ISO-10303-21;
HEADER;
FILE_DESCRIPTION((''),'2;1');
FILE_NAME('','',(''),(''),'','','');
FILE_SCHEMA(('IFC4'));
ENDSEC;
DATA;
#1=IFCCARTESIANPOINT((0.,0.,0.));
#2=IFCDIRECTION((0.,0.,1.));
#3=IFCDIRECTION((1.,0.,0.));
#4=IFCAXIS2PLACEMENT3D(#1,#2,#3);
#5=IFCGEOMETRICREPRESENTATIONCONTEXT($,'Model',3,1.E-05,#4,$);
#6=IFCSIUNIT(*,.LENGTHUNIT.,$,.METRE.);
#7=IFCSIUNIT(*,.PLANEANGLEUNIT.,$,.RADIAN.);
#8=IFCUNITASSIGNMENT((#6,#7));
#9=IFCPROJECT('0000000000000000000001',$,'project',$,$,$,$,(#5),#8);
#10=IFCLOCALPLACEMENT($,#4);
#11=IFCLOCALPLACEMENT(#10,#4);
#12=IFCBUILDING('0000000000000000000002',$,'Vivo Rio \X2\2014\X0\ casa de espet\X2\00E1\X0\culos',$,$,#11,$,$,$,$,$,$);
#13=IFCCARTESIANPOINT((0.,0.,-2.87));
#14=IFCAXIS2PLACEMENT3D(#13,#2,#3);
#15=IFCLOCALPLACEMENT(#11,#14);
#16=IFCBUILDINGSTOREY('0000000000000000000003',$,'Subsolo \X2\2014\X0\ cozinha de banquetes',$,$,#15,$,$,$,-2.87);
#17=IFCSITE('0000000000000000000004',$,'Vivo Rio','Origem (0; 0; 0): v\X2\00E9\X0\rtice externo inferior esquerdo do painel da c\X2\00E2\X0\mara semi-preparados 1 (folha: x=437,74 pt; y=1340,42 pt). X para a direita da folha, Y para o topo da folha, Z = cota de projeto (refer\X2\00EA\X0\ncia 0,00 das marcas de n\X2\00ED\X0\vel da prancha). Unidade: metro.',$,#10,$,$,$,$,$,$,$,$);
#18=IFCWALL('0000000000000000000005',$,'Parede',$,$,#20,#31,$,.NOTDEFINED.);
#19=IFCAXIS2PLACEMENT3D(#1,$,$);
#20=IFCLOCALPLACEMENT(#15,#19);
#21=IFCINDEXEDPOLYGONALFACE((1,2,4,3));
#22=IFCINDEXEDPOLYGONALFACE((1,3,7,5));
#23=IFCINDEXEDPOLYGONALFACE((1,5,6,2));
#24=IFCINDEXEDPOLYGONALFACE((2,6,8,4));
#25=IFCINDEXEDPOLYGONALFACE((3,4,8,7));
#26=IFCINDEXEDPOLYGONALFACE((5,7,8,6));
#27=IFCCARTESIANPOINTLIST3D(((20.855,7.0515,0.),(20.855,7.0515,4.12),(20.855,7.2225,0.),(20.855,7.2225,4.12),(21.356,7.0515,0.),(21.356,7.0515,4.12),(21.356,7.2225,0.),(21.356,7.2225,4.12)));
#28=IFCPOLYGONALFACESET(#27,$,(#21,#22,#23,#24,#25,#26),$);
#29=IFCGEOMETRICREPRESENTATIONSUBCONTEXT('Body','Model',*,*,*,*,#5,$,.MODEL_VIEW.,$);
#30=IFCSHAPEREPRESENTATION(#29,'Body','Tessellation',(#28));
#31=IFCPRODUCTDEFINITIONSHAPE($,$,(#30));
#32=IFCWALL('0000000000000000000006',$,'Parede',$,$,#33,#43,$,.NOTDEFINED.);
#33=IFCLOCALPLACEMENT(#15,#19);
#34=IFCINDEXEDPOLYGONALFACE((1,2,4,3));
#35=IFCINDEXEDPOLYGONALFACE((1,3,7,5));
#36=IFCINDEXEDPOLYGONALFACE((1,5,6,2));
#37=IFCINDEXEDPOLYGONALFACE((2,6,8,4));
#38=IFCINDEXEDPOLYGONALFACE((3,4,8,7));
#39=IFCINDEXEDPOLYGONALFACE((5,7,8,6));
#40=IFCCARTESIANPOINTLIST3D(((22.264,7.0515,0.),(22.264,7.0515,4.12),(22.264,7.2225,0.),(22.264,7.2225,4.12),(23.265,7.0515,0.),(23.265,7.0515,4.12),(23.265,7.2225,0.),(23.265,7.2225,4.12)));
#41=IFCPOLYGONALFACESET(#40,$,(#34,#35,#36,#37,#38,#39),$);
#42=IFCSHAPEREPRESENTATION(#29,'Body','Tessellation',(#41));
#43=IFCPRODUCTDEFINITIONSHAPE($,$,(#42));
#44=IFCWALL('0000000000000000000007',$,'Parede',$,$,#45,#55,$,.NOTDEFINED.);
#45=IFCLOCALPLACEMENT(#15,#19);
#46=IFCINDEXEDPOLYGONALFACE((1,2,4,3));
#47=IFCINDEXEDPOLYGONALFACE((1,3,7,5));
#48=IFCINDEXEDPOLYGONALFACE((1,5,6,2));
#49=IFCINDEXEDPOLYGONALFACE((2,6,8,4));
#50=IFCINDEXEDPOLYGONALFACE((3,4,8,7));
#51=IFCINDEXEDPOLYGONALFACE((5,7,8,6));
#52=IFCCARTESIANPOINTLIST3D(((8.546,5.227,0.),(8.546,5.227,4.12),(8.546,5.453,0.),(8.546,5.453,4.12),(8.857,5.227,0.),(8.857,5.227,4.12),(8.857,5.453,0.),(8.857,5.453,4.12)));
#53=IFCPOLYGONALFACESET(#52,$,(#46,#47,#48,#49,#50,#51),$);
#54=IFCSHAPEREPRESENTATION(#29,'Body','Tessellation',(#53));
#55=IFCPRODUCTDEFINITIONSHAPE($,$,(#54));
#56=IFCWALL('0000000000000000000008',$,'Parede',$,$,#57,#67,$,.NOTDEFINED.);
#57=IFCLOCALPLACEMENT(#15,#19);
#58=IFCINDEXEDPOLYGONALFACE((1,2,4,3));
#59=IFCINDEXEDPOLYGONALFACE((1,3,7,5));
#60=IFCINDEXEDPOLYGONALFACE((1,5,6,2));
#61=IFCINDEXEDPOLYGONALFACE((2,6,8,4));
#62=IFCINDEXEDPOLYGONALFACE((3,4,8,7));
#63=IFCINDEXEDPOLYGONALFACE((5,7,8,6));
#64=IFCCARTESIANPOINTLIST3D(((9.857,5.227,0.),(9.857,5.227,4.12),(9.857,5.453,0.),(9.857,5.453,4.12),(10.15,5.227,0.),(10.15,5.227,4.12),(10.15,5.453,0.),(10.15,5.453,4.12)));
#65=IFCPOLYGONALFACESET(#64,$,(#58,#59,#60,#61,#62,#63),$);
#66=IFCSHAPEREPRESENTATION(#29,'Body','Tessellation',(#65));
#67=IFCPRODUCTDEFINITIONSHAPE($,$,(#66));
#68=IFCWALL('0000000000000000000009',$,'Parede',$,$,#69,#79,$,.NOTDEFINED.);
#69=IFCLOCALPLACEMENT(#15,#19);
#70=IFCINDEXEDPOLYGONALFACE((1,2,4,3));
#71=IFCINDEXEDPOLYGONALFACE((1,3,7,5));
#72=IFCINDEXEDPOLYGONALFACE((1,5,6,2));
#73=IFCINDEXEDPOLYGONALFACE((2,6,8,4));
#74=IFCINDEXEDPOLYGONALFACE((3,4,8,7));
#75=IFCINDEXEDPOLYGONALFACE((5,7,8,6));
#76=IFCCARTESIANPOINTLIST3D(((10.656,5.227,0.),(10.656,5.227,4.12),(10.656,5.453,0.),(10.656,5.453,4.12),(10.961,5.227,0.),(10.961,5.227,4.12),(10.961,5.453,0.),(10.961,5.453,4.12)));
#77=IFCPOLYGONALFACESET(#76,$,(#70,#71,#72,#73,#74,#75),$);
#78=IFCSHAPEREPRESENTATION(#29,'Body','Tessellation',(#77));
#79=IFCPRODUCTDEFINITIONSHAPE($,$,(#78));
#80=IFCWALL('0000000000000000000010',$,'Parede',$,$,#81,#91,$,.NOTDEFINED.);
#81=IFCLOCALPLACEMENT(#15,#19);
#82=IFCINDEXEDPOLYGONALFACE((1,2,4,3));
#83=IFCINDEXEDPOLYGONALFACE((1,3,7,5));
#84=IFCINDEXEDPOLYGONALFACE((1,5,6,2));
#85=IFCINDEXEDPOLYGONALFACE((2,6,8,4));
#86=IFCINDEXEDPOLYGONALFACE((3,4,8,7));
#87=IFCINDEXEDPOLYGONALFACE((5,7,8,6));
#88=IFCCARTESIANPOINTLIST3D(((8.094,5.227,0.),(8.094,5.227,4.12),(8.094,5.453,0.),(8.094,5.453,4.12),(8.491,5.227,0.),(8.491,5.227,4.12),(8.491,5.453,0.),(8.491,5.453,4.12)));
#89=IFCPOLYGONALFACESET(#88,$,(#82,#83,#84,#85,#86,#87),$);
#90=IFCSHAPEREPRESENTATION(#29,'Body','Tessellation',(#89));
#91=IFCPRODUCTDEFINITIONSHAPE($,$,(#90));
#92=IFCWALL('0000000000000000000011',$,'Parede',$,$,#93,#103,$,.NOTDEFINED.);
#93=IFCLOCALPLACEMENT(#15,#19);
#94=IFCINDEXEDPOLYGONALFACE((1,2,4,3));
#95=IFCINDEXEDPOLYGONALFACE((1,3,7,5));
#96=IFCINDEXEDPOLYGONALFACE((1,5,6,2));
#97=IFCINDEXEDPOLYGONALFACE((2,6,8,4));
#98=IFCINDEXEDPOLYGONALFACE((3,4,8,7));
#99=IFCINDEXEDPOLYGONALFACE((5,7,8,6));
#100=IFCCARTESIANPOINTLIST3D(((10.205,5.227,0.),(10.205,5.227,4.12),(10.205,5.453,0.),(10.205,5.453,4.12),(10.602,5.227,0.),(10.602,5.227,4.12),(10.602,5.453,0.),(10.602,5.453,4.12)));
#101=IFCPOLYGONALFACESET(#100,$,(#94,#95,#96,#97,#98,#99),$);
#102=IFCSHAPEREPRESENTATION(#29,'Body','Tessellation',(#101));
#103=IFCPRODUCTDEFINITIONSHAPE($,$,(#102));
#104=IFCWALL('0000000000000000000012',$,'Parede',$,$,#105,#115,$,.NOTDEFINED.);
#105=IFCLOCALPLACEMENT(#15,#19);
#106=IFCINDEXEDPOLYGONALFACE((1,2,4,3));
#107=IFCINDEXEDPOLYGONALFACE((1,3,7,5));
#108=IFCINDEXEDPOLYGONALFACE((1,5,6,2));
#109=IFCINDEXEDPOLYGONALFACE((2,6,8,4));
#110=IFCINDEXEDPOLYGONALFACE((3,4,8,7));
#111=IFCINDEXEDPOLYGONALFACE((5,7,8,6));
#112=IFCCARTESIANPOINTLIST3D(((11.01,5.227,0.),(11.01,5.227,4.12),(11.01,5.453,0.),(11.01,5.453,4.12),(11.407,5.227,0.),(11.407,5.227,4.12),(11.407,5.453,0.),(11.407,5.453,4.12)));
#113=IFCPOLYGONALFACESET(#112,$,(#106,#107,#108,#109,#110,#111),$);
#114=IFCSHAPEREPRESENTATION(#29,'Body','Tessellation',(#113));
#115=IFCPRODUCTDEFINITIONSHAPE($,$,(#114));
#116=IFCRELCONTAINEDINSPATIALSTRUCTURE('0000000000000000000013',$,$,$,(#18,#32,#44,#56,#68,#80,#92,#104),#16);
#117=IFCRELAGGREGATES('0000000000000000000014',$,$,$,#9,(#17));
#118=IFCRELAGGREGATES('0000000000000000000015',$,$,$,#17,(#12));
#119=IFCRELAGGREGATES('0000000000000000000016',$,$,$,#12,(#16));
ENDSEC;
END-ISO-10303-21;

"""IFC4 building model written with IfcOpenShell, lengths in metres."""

from ifc_helpers import new_model, si_unit, frame, origin_with_axes, origin_2d, place, context, subcontext, project, spatial, rectangle, extrude, element, save


model = new_model("IFC4")

# Units and contexts
model_context = context("Model", 3, precision=1e-05, world=origin_with_axes())
body_context = subcontext(model_context, "Body", "Model", "MODEL_VIEW")
ifc_project = project(units=[si_unit("LENGTHUNIT", "METRE"), si_unit("PLANEANGLEUNIT", "RADIAN")], contexts=[model_context])

# Site, building, storey
site_placement = place(None, origin_with_axes())
site = spatial("IfcSite", under=ifc_project, at=site_placement, Name="Vivo Rio", Description="Origem (0; 0; 0): vértice externo inferior esquerdo do painel da câmara semi-preparados 1 (folha: x=437,74 pt; y=1340,42 pt). X para a direita da folha, Y para o topo da folha, Z = cota de projeto (referência 0,00 das marcas de nível da prancha). Unidade: metro.")
building_placement = place(site_placement, origin_with_axes())
building = spatial("IfcBuilding", under=site, at=building_placement, Name="Vivo Rio — casa de espetáculos")
storey_placement = place(building_placement, frame((0.0, 0.0, -2.87), z_axis=(0.0, 0.0, 1.0), x_axis=(1.0, 0.0, 0.0)))
storey = spatial("IfcBuildingStorey", under=building, at=storey_placement, Name="Subsolo — cozinha de banquetes", Elevation=-2.87)

# Walls
wall_1_placement = place(storey_placement, origin_with_axes())
element("IfcWall", 1, at=wall_1_placement, inside=storey, Name="Parede", PredefinedType="NOTDEFINED", context=body_context, shape_type="SweptSolid", body=[
    extrude(rectangle(XDim=0.501, YDim=0.171, at=origin_2d()), frame((21.1055, 7.137, 0.0), z_axis=(0.0, 0.0, 1.0), x_axis=(1.0, 0.0, 0.0)), (0.0, 0.0, 1.0), 4.12),
])
wall_2_placement = place(storey_placement, origin_with_axes())
element("IfcWall", 2, at=wall_2_placement, inside=storey, Name="Parede", PredefinedType="NOTDEFINED", context=body_context, shape_type="SweptSolid", body=[
    extrude(rectangle(XDim=1.001, YDim=0.171, at=origin_2d()), frame((22.7645, 7.137, 0.0), z_axis=(0.0, 0.0, 1.0), x_axis=(1.0, 0.0, 0.0)), (0.0, 0.0, 1.0), 4.12),
])
wall_3_placement = place(storey_placement, origin_with_axes())
element("IfcWall", 3, at=wall_3_placement, inside=storey, Name="Parede", PredefinedType="NOTDEFINED", context=body_context, shape_type="SweptSolid", body=[
    extrude(rectangle(XDim=0.311, YDim=0.226, at=origin_2d()), frame((8.7015, 5.34, 0.0), z_axis=(0.0, 0.0, 1.0), x_axis=(1.0, 0.0, 0.0)), (0.0, 0.0, 1.0), 4.12),
])
wall_4_placement = place(storey_placement, origin_with_axes())
element("IfcWall", 4, at=wall_4_placement, inside=storey, Name="Parede", PredefinedType="NOTDEFINED", context=body_context, shape_type="SweptSolid", body=[
    extrude(rectangle(XDim=0.293, YDim=0.226, at=origin_2d()), frame((10.0035, 5.34, 0.0), z_axis=(0.0, 0.0, 1.0), x_axis=(1.0, 0.0, 0.0)), (0.0, 0.0, 1.0), 4.12),
])
wall_5_placement = place(storey_placement, origin_with_axes())
element("IfcWall", 5, at=wall_5_placement, inside=storey, Name="Parede", PredefinedType="NOTDEFINED", context=body_context, shape_type="SweptSolid", body=[
    extrude(rectangle(XDim=0.305, YDim=0.226, at=origin_2d()), frame((10.8085, 5.34, 0.0), z_axis=(0.0, 0.0, 1.0), x_axis=(1.0, 0.0, 0.0)), (0.0, 0.0, 1.0), 4.12),
])
wall_6_placement = place(storey_placement, origin_with_axes())
element("IfcWall", 6, at=wall_6_placement, inside=storey, Name="Parede", PredefinedType="NOTDEFINED", context=body_context, shape_type="SweptSolid", body=[
    extrude(rectangle(XDim=0.397, YDim=0.226, at=origin_2d()), frame((8.2925, 5.34, 0.0), z_axis=(0.0, 0.0, 1.0), x_axis=(1.0, 0.0, 0.0)), (0.0, 0.0, 1.0), 4.12),
])
wall_7_placement = place(storey_placement, origin_with_axes())
element("IfcWall", 7, at=wall_7_placement, inside=storey, Name="Parede", PredefinedType="NOTDEFINED", context=body_context, shape_type="SweptSolid", body=[
    extrude(rectangle(XDim=0.397, YDim=0.226, at=origin_2d()), frame((10.4035, 5.34, 0.0), z_axis=(0.0, 0.0, 1.0), x_axis=(1.0, 0.0, 0.0)), (0.0, 0.0, 1.0), 4.12),
])
wall_8_placement = place(storey_placement, origin_with_axes())
element("IfcWall", 8, at=wall_8_placement, inside=storey, Name="Parede", PredefinedType="NOTDEFINED", context=body_context, shape_type="SweptSolid", body=[
    extrude(rectangle(XDim=0.397, YDim=0.226, at=origin_2d()), frame((11.2085, 5.34, 0.0), z_axis=(0.0, 0.0, 1.0), x_axis=(1.0, 0.0, 0.0)), (0.0, 0.0, 1.0), 4.12),
])

save(model, "model.ifc")
